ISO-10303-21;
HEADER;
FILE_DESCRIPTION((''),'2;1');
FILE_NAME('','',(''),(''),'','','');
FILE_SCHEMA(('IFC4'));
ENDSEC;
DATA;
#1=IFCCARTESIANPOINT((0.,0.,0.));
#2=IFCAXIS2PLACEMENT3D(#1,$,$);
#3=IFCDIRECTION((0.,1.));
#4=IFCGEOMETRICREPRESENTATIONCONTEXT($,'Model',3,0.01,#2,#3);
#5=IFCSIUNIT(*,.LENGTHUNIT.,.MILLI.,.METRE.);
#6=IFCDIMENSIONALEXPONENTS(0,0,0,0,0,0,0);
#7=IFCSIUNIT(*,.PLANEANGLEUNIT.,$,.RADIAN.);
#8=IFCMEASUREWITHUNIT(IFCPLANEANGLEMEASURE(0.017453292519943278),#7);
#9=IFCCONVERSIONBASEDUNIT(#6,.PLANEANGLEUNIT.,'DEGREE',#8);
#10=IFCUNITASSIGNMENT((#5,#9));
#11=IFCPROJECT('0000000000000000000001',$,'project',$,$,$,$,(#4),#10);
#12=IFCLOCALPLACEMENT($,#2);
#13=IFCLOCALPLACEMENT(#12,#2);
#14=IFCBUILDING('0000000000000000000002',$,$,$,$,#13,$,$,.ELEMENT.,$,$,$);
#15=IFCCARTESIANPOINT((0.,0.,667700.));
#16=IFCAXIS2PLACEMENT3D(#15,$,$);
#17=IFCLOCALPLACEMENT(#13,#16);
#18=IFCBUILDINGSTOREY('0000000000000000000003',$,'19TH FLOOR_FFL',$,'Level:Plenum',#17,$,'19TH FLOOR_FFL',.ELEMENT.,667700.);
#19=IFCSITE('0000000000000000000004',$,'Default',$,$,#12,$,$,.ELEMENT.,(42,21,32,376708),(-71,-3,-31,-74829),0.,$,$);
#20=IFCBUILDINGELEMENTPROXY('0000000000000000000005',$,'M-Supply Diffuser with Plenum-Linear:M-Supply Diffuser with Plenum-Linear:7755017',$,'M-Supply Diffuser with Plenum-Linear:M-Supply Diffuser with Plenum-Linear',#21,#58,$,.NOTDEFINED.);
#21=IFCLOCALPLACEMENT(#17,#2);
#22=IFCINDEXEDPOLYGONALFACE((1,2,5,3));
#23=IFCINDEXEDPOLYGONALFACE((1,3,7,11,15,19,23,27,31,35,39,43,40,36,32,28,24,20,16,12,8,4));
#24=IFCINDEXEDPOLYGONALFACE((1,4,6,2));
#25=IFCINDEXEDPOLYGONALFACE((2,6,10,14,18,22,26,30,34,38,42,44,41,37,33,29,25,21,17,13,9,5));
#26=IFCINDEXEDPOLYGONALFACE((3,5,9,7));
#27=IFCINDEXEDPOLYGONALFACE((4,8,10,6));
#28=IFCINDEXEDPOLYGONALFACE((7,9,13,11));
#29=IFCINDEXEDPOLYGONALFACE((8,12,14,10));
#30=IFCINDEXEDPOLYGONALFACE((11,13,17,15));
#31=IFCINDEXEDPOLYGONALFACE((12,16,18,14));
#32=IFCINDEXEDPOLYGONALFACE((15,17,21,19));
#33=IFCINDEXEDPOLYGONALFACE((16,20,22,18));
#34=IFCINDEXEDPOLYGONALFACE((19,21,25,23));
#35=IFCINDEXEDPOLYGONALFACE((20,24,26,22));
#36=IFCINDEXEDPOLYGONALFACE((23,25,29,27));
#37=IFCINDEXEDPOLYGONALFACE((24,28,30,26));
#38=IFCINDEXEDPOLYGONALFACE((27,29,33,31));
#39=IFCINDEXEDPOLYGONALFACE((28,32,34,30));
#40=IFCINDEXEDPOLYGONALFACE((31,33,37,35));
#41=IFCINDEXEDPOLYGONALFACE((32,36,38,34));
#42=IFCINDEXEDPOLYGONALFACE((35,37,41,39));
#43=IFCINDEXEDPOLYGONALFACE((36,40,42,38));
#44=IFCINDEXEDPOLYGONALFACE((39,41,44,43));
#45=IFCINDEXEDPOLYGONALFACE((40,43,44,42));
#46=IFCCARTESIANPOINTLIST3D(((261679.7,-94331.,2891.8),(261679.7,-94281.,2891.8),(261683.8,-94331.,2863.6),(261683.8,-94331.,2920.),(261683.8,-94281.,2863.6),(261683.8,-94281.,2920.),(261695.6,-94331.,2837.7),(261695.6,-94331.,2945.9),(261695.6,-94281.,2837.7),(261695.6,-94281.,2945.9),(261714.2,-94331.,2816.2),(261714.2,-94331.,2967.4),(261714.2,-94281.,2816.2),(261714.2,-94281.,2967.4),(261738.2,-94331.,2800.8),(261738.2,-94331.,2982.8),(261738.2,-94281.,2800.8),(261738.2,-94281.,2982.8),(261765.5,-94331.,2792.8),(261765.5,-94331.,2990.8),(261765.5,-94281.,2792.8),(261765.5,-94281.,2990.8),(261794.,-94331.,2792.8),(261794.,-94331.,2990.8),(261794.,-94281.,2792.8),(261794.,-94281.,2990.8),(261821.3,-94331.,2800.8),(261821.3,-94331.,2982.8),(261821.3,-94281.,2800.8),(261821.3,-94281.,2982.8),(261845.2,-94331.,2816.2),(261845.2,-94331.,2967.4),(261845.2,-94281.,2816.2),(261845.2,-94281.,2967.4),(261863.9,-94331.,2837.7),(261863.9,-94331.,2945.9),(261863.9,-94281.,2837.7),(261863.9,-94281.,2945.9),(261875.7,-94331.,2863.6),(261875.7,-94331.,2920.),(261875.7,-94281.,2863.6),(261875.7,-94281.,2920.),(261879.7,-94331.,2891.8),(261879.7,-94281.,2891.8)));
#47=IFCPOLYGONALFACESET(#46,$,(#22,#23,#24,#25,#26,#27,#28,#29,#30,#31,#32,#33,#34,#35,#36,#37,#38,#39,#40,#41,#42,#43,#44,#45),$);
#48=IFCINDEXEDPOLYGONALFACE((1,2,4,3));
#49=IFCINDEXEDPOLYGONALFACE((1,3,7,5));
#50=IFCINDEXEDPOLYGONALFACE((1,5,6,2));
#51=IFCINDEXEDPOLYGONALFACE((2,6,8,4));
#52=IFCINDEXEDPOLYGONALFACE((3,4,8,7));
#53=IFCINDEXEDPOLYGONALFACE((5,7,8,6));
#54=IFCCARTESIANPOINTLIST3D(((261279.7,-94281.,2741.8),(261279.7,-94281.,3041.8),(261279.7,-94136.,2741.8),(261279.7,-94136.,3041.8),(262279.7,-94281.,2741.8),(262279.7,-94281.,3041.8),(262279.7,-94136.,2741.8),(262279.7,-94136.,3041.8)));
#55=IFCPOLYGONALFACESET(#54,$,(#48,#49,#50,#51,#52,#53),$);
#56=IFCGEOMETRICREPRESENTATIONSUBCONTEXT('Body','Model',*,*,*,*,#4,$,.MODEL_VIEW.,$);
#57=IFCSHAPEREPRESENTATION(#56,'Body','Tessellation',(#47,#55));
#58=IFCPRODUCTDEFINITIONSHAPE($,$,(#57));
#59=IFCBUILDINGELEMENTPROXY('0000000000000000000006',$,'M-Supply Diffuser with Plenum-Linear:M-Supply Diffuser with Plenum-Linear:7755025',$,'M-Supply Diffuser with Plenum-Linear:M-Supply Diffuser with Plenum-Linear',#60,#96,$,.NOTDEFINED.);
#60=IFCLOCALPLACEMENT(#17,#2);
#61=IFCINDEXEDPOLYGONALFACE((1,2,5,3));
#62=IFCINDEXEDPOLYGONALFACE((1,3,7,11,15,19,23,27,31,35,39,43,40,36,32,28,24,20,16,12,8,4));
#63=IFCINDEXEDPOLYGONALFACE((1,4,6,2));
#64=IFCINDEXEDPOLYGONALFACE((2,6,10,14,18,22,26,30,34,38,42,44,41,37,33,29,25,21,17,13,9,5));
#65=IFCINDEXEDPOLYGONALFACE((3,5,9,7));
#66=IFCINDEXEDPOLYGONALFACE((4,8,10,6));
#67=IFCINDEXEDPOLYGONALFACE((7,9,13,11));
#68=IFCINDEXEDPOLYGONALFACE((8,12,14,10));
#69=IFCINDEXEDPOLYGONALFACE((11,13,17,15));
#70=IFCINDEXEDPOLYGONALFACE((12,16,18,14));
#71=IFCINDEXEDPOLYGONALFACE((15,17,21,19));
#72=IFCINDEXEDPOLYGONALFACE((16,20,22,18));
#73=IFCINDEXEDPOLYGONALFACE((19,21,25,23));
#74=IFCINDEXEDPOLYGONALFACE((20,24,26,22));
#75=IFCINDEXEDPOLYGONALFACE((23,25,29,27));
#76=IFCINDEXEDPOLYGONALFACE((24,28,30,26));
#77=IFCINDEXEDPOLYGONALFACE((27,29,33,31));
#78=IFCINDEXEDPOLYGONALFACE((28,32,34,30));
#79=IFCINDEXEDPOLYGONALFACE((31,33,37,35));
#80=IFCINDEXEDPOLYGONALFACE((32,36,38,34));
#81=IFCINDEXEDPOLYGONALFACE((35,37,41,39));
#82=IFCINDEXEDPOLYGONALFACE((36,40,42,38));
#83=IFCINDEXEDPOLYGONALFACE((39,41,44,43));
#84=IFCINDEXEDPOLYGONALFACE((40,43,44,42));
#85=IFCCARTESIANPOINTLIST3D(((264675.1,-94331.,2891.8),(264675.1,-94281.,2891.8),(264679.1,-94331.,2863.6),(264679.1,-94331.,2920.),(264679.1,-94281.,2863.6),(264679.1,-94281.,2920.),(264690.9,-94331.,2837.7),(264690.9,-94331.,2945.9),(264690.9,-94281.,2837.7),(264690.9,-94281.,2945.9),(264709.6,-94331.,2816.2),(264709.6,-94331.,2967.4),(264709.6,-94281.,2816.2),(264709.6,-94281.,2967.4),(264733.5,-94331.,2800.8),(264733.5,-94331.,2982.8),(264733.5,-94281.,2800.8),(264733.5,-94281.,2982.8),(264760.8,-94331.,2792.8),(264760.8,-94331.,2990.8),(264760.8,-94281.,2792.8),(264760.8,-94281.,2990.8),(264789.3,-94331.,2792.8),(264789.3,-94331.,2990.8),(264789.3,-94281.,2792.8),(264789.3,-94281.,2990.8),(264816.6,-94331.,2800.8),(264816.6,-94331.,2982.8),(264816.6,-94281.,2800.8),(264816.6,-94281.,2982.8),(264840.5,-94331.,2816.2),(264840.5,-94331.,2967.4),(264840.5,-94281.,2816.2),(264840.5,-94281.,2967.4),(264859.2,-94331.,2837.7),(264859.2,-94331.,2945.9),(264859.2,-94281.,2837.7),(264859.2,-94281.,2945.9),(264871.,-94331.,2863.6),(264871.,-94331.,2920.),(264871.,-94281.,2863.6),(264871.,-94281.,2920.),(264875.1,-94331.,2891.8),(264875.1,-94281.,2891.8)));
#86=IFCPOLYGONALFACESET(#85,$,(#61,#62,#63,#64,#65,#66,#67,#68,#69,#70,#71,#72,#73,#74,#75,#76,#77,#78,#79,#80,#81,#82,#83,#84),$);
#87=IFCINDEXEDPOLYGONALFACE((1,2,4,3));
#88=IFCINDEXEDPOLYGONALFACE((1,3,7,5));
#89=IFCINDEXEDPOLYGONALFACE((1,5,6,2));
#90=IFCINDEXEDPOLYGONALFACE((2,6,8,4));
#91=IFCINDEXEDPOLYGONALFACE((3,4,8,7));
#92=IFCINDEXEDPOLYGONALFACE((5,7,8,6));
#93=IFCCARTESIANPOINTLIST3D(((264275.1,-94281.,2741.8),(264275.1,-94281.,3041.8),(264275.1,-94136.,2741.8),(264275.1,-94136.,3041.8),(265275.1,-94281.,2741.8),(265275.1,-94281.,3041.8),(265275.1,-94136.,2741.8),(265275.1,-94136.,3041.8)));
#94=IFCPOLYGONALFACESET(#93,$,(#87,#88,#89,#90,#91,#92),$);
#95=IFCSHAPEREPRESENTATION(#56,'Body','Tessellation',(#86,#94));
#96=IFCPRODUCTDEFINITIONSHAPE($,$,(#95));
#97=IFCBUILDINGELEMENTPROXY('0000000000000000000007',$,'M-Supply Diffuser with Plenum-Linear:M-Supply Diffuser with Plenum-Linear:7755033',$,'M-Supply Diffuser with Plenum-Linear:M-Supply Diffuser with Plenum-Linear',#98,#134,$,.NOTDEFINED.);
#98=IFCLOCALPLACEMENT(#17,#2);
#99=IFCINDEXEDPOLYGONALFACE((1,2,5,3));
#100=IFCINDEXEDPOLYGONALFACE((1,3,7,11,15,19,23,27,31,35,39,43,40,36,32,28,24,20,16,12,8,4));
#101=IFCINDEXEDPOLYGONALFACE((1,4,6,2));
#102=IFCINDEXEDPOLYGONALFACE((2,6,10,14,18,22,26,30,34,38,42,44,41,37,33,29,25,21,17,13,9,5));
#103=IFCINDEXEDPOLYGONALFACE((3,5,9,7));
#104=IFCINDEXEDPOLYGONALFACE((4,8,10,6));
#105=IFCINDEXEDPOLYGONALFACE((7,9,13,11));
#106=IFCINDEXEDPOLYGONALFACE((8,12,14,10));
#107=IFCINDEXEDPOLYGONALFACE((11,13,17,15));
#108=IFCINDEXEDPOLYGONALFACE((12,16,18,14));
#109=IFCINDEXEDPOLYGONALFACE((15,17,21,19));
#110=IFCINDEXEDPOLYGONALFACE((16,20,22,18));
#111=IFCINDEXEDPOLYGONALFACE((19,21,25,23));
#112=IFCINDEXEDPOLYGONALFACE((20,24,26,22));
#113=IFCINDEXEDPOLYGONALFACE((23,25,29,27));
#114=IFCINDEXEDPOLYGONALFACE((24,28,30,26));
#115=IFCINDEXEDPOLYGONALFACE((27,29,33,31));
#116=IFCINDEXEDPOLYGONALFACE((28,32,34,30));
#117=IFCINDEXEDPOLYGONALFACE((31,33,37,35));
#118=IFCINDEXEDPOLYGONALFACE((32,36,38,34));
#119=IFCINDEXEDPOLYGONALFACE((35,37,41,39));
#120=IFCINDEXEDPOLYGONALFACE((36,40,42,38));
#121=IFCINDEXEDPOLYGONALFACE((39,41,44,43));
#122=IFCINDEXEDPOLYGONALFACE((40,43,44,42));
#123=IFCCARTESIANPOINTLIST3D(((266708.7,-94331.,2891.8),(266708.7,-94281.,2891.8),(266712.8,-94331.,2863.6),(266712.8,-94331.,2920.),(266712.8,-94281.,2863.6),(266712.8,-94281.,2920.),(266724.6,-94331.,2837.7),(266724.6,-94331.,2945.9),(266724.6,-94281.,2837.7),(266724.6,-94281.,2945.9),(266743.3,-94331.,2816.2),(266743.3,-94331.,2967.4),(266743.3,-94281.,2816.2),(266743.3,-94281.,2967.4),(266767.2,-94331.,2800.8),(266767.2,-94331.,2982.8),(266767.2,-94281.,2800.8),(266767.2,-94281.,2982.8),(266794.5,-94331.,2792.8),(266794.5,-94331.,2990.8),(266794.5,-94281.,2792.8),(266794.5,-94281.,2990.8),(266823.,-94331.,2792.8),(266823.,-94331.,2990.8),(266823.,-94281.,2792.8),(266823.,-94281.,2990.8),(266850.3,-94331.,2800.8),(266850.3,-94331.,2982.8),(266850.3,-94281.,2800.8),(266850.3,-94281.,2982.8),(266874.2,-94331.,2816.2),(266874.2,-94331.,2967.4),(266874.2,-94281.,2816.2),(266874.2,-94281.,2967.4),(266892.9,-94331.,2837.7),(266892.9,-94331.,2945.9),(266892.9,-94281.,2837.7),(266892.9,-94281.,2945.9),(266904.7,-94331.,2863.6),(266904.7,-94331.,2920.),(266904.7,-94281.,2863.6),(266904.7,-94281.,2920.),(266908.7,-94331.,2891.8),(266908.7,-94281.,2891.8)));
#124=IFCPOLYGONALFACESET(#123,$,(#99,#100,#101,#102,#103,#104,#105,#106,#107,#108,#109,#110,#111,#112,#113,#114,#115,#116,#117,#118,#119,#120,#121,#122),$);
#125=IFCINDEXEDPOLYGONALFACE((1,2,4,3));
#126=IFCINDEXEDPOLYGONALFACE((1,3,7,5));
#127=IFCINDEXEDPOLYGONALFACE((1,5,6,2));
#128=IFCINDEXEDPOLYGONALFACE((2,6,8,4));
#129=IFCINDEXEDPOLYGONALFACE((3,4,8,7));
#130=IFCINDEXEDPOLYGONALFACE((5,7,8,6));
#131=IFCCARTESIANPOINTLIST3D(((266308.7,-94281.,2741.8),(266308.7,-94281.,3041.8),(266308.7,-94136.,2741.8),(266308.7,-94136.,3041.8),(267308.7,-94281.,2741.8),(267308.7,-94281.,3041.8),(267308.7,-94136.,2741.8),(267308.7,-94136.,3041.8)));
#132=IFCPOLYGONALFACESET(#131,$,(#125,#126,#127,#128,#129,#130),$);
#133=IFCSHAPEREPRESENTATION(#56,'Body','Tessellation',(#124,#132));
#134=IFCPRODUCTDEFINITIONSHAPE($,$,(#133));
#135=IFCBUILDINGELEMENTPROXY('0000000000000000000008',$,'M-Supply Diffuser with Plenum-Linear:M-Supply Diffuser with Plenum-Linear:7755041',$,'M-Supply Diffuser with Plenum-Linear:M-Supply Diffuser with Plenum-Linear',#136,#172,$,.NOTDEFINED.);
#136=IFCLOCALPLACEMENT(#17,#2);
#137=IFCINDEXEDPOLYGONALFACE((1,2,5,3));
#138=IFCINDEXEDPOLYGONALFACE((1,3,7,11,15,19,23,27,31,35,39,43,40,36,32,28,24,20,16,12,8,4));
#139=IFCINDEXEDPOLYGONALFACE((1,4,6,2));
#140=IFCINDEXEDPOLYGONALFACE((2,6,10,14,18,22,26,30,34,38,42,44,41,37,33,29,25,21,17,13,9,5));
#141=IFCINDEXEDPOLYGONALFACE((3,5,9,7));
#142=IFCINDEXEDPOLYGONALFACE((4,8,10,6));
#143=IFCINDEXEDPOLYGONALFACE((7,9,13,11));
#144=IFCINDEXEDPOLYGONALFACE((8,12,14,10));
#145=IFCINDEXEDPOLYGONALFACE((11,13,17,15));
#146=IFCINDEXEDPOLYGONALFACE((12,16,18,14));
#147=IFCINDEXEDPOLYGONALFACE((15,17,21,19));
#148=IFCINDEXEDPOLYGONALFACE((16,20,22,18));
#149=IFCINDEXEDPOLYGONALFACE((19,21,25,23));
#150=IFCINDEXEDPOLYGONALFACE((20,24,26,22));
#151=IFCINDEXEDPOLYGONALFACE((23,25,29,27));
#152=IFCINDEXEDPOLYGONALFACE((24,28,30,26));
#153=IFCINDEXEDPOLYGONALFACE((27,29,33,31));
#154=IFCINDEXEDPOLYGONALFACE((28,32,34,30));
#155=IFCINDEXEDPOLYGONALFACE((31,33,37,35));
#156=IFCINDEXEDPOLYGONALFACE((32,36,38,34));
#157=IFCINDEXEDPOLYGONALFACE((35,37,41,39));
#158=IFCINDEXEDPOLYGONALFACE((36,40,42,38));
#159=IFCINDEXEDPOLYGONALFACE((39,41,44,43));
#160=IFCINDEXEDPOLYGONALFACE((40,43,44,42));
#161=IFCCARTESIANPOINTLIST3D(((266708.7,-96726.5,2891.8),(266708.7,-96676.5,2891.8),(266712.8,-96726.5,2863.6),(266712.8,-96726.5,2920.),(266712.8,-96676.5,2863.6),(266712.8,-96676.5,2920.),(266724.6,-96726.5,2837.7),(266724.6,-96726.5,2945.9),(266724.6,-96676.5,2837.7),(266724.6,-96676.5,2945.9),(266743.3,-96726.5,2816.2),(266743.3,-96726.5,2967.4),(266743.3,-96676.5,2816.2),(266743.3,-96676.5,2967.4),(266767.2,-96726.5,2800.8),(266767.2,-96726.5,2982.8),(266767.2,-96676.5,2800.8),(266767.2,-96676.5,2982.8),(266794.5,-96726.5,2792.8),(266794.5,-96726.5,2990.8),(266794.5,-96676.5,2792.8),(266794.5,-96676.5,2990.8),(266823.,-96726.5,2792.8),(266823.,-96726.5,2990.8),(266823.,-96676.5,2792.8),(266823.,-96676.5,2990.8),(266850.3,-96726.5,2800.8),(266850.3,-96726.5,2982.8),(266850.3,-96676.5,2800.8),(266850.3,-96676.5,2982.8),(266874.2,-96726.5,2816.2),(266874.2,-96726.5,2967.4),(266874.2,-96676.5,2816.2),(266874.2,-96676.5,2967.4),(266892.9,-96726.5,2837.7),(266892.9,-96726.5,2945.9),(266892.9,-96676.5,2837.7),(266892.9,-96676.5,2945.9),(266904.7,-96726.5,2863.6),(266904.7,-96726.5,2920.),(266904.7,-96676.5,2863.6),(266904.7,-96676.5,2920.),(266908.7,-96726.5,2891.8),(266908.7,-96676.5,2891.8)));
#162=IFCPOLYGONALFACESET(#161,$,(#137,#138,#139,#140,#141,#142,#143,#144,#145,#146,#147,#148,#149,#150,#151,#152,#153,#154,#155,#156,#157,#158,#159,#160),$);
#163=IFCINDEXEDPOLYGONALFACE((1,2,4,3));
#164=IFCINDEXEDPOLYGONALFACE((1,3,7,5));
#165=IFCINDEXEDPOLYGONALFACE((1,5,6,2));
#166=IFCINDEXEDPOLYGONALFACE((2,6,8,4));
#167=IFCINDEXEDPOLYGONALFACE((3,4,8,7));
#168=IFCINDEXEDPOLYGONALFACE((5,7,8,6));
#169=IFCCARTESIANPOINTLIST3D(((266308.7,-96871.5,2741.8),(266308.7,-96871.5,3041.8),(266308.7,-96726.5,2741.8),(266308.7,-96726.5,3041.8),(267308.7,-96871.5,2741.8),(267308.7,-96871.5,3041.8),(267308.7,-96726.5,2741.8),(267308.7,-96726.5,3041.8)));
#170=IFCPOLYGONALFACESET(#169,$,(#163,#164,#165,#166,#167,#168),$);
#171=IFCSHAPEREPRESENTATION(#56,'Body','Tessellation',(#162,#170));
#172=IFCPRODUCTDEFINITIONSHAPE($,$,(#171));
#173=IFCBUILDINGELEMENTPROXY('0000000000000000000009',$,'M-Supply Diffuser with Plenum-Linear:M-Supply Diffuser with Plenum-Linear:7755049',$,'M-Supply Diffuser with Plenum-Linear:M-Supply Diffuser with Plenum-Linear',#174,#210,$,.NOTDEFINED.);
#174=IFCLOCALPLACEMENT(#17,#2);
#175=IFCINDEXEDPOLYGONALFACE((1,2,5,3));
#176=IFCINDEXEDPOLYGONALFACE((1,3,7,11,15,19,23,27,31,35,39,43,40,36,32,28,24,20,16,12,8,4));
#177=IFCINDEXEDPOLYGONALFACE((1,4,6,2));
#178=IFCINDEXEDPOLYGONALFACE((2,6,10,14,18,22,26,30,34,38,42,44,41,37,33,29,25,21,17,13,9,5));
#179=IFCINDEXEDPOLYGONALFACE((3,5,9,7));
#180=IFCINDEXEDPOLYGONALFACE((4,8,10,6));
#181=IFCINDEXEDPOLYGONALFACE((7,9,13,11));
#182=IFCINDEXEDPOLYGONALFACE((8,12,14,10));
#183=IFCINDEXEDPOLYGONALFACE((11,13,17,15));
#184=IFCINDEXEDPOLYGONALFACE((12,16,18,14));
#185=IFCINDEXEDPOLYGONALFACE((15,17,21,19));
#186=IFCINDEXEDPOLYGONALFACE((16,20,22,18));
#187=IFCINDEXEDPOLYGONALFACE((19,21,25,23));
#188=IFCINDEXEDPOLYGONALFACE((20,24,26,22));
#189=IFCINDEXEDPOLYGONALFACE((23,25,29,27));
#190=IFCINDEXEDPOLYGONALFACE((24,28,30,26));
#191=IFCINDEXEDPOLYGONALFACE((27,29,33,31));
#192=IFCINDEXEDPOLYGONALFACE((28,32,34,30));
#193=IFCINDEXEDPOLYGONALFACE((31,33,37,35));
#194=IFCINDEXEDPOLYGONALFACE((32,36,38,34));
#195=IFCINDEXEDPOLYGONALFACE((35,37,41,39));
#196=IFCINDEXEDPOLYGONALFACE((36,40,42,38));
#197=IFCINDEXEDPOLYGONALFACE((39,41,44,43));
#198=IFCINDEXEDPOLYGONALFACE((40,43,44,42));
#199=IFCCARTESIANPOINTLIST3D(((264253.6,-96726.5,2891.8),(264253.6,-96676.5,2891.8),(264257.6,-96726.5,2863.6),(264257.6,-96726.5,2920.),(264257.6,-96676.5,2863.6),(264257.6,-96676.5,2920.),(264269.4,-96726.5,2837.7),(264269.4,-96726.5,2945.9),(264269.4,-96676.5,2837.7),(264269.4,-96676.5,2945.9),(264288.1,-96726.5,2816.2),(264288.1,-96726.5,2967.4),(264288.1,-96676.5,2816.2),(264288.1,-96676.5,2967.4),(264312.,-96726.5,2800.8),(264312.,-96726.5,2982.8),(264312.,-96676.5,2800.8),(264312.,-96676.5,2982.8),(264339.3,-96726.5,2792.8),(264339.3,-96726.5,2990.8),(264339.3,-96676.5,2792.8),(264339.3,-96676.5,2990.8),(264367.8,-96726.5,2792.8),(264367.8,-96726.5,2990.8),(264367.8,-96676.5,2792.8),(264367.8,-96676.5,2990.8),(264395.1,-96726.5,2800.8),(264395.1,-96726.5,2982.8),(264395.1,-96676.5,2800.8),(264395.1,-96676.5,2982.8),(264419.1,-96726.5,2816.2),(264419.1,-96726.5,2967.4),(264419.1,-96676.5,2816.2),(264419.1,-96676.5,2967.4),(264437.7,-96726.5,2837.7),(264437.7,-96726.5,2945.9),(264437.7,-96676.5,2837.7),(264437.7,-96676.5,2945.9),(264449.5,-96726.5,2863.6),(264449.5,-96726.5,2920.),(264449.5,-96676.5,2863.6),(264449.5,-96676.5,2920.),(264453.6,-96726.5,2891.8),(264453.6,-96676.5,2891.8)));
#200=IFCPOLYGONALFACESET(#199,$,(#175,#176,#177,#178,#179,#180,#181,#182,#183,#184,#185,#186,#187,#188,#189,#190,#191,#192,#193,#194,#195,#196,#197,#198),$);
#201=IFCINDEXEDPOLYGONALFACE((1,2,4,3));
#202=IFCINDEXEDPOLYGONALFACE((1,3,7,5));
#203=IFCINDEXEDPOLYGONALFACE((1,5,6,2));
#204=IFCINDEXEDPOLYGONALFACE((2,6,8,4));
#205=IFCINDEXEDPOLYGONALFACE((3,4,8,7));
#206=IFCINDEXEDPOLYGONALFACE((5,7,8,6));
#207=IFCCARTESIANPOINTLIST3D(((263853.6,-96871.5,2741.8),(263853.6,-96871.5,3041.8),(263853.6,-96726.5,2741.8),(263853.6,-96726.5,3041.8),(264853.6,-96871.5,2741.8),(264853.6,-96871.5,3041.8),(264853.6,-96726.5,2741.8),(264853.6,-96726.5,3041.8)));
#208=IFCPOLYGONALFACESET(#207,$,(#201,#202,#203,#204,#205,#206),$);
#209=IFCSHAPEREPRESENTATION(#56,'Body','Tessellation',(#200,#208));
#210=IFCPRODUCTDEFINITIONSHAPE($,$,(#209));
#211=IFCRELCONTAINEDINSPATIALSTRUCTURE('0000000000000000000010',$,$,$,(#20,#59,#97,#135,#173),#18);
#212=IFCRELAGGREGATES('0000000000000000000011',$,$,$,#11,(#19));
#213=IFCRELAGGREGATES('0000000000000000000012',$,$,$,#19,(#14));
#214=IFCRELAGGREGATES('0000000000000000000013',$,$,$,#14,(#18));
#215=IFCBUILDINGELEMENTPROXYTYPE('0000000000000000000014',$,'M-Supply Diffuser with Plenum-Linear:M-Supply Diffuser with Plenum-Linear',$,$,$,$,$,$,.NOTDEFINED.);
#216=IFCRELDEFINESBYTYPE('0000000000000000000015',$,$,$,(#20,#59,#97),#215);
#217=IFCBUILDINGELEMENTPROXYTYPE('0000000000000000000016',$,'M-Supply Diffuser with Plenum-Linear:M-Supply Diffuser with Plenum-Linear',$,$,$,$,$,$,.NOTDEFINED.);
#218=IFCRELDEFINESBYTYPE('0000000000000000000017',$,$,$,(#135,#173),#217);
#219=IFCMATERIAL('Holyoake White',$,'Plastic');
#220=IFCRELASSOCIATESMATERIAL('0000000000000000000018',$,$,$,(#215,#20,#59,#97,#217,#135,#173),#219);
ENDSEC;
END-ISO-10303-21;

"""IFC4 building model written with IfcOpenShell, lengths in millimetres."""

from ifc_helpers import new_model, entity, si_unit, converted_unit, direction, frame, origin, place, context, subcontext, project, spatial, arc, indexed_curve, outline, extrude, source, transform, mapped, material, type_object, type_shapes, element, save


model = new_model("IFC4")

# Units and contexts
model_context = context("Model", 3, precision=0.01, world=origin(), true_north=direction((0.0, 1.0)))
body_context = subcontext(model_context, "Body", "Model", "MODEL_VIEW")
ifc_project = project(units=[si_unit("LENGTHUNIT", "METRE", prefix="MILLI"), converted_unit("PLANEANGLEUNIT", "DEGREE", entity("IfcPlaneAngleMeasure", 0.017453292519943278), si_unit("PLANEANGLEUNIT", "RADIAN"), dimensions=[0, 0, 0, 0, 0, 0, 0])], contexts=[model_context])

# Site, building, storey
site_placement = place(None, origin())
site = spatial("IfcSite", under=ifc_project, at=site_placement, Name="Default", CompositionType="ELEMENT", RefLatitude=(42, 21, 32, 376708), RefLongitude=(-71, -3, -31, -74829), RefElevation=0.0)
building_placement = place(site_placement, origin())
building = spatial("IfcBuilding", under=site, at=building_placement, CompositionType="ELEMENT")
storey_placement = place(building_placement, frame((0.0, 0.0, 667700.0)))
storey = spatial("IfcBuildingStorey", under=building, at=storey_placement, Name="19TH FLOOR_FFL", ObjectType="Level:Plenum", LongName="19TH FLOOR_FFL", CompositionType="ELEMENT", Elevation=667700.0)

# Building element proxies
ifc_material_1 = material(Name="Holyoake White", Category="Plastic")
building_element_proxy_type_1 = type_object("IfcBuildingElementProxyType", Name="M-Supply Diffuser with Plenum-Linear:M-Supply Diffuser with Plenum-Linear", PredefinedType="NOTDEFINED", material=ifc_material_1)
shared_shape_1 = source(origin(), body_context, "Body", "SweptSolid", [
    extrude(outline(indexed_curve([(-100.0, 0.0), (0.0, -100.0), (100.0, 0.0), (0.0, 100.0)], segments=[arc(1, 2, 3), arc(3, 4, 1)], self_intersect=False)), frame((0.0, 72.5, 195.0), z_axis=(0.0, 1.0, 0.0), x_axis=(1.0, 0.0, 0.0)), (0.0, 0.0, 1.0), 50.0),
    extrude(outline(indexed_curve([(-72.5, -500.0), (72.5, -500.0), (72.5, 500.0), (-72.5, 500.0), (-72.5, -500.0)], self_intersect=False)), frame((0.0, 0.0, 45.0), z_axis=(0.0, 0.0, 1.0), x_axis=(0.0, 1.0, 0.0)), (0.0, 0.0, 1.0), 300.0),
])
type_shapes(building_element_proxy_type_1, [shared_shape_1])
for number, where, z_axis, x_axis, name in (
    (1, (261779.7, -94208.5, 2696.8), (0.0, 0.0, 1.0), (-1.0, 0.0, 0.0), "M-Supply Diffuser with Plenum-Linear:M-Supply Diffuser with Plenum-Linear:7755017"),
    (2, (264775.1, -94208.5, 2696.8), (0.0, 0.0, 1.0), (-1.0, 0.0, 0.0), "M-Supply Diffuser with Plenum-Linear:M-Supply Diffuser with Plenum-Linear:7755025"),
    (3, (266808.7, -94208.5, 2696.8), (0.0, 0.0, 1.0), (-1.0, 0.0, 0.0), "M-Supply Diffuser with Plenum-Linear:M-Supply Diffuser with Plenum-Linear:7755033"),
):
    element("IfcBuildingElementProxy", number, at=place(storey_placement, frame(where, z_axis=z_axis, x_axis=x_axis)), inside=storey, type_object=building_element_proxy_type_1, material=ifc_material_1, Name=name, ObjectType="M-Supply Diffuser with Plenum-Linear:M-Supply Diffuser with Plenum-Linear", PredefinedType="NOTDEFINED", context=body_context, shape_type="MappedRepresentation", body=[
        mapped(shared_shape_1, transform((0.0, 0.0, 0.0), scale=1.0)),
    ])
building_element_proxy_type_2 = type_object("IfcBuildingElementProxyType", Name="M-Supply Diffuser with Plenum-Linear:M-Supply Diffuser with Plenum-Linear", PredefinedType="NOTDEFINED", material=ifc_material_1)
shared_shape_2 = source(origin(), body_context, "Body", "SweptSolid", [
    extrude(outline(indexed_curve([(-100.0, 0.0), (0.0, -100.0), (100.0, 0.0), (0.0, 100.0)], segments=[arc(1, 2, 3), arc(3, 4, 1)], self_intersect=False)), frame((0.0, -122.5, 195.0), z_axis=(0.0, 1.0, 0.0), x_axis=(1.0, 0.0, 0.0)), (0.0, 0.0, 1.0), 50.0),
    extrude(outline(indexed_curve([(-500.0, -72.5), (500.0, -72.5), (500.0, 72.5), (-500.0, 72.5), (-500.0, -72.5)], self_intersect=False)), frame((0.0, 0.0, 45.0), z_axis=(0.0, 0.0, 1.0), x_axis=(-1.0, 0.0, 0.0)), (0.0, 0.0, 1.0), 300.0),
])
type_shapes(building_element_proxy_type_2, [shared_shape_2])
for number, where, z_axis, x_axis, name in (
    (4, (266808.7, -96799.0, 2696.8), (0.0, 0.0, 1.0), (-1.0, 0.0, 0.0), "M-Supply Diffuser with Plenum-Linear:M-Supply Diffuser with Plenum-Linear:7755041"),
    (5, (264353.6, -96799.0, 2696.8), (0.0, 0.0, 1.0), (-1.0, 0.0, 0.0), "M-Supply Diffuser with Plenum-Linear:M-Supply Diffuser with Plenum-Linear:7755049"),
):
    element("IfcBuildingElementProxy", number, at=place(storey_placement, frame(where, z_axis=z_axis, x_axis=x_axis)), inside=storey, type_object=building_element_proxy_type_2, material=ifc_material_1, Name=name, ObjectType="M-Supply Diffuser with Plenum-Linear:M-Supply Diffuser with Plenum-Linear", PredefinedType="NOTDEFINED", context=body_context, shape_type="MappedRepresentation", body=[
        mapped(shared_shape_2, transform((0.0, 0.0, 0.0), scale=1.0)),
    ])

save(model, "model.ifc")
